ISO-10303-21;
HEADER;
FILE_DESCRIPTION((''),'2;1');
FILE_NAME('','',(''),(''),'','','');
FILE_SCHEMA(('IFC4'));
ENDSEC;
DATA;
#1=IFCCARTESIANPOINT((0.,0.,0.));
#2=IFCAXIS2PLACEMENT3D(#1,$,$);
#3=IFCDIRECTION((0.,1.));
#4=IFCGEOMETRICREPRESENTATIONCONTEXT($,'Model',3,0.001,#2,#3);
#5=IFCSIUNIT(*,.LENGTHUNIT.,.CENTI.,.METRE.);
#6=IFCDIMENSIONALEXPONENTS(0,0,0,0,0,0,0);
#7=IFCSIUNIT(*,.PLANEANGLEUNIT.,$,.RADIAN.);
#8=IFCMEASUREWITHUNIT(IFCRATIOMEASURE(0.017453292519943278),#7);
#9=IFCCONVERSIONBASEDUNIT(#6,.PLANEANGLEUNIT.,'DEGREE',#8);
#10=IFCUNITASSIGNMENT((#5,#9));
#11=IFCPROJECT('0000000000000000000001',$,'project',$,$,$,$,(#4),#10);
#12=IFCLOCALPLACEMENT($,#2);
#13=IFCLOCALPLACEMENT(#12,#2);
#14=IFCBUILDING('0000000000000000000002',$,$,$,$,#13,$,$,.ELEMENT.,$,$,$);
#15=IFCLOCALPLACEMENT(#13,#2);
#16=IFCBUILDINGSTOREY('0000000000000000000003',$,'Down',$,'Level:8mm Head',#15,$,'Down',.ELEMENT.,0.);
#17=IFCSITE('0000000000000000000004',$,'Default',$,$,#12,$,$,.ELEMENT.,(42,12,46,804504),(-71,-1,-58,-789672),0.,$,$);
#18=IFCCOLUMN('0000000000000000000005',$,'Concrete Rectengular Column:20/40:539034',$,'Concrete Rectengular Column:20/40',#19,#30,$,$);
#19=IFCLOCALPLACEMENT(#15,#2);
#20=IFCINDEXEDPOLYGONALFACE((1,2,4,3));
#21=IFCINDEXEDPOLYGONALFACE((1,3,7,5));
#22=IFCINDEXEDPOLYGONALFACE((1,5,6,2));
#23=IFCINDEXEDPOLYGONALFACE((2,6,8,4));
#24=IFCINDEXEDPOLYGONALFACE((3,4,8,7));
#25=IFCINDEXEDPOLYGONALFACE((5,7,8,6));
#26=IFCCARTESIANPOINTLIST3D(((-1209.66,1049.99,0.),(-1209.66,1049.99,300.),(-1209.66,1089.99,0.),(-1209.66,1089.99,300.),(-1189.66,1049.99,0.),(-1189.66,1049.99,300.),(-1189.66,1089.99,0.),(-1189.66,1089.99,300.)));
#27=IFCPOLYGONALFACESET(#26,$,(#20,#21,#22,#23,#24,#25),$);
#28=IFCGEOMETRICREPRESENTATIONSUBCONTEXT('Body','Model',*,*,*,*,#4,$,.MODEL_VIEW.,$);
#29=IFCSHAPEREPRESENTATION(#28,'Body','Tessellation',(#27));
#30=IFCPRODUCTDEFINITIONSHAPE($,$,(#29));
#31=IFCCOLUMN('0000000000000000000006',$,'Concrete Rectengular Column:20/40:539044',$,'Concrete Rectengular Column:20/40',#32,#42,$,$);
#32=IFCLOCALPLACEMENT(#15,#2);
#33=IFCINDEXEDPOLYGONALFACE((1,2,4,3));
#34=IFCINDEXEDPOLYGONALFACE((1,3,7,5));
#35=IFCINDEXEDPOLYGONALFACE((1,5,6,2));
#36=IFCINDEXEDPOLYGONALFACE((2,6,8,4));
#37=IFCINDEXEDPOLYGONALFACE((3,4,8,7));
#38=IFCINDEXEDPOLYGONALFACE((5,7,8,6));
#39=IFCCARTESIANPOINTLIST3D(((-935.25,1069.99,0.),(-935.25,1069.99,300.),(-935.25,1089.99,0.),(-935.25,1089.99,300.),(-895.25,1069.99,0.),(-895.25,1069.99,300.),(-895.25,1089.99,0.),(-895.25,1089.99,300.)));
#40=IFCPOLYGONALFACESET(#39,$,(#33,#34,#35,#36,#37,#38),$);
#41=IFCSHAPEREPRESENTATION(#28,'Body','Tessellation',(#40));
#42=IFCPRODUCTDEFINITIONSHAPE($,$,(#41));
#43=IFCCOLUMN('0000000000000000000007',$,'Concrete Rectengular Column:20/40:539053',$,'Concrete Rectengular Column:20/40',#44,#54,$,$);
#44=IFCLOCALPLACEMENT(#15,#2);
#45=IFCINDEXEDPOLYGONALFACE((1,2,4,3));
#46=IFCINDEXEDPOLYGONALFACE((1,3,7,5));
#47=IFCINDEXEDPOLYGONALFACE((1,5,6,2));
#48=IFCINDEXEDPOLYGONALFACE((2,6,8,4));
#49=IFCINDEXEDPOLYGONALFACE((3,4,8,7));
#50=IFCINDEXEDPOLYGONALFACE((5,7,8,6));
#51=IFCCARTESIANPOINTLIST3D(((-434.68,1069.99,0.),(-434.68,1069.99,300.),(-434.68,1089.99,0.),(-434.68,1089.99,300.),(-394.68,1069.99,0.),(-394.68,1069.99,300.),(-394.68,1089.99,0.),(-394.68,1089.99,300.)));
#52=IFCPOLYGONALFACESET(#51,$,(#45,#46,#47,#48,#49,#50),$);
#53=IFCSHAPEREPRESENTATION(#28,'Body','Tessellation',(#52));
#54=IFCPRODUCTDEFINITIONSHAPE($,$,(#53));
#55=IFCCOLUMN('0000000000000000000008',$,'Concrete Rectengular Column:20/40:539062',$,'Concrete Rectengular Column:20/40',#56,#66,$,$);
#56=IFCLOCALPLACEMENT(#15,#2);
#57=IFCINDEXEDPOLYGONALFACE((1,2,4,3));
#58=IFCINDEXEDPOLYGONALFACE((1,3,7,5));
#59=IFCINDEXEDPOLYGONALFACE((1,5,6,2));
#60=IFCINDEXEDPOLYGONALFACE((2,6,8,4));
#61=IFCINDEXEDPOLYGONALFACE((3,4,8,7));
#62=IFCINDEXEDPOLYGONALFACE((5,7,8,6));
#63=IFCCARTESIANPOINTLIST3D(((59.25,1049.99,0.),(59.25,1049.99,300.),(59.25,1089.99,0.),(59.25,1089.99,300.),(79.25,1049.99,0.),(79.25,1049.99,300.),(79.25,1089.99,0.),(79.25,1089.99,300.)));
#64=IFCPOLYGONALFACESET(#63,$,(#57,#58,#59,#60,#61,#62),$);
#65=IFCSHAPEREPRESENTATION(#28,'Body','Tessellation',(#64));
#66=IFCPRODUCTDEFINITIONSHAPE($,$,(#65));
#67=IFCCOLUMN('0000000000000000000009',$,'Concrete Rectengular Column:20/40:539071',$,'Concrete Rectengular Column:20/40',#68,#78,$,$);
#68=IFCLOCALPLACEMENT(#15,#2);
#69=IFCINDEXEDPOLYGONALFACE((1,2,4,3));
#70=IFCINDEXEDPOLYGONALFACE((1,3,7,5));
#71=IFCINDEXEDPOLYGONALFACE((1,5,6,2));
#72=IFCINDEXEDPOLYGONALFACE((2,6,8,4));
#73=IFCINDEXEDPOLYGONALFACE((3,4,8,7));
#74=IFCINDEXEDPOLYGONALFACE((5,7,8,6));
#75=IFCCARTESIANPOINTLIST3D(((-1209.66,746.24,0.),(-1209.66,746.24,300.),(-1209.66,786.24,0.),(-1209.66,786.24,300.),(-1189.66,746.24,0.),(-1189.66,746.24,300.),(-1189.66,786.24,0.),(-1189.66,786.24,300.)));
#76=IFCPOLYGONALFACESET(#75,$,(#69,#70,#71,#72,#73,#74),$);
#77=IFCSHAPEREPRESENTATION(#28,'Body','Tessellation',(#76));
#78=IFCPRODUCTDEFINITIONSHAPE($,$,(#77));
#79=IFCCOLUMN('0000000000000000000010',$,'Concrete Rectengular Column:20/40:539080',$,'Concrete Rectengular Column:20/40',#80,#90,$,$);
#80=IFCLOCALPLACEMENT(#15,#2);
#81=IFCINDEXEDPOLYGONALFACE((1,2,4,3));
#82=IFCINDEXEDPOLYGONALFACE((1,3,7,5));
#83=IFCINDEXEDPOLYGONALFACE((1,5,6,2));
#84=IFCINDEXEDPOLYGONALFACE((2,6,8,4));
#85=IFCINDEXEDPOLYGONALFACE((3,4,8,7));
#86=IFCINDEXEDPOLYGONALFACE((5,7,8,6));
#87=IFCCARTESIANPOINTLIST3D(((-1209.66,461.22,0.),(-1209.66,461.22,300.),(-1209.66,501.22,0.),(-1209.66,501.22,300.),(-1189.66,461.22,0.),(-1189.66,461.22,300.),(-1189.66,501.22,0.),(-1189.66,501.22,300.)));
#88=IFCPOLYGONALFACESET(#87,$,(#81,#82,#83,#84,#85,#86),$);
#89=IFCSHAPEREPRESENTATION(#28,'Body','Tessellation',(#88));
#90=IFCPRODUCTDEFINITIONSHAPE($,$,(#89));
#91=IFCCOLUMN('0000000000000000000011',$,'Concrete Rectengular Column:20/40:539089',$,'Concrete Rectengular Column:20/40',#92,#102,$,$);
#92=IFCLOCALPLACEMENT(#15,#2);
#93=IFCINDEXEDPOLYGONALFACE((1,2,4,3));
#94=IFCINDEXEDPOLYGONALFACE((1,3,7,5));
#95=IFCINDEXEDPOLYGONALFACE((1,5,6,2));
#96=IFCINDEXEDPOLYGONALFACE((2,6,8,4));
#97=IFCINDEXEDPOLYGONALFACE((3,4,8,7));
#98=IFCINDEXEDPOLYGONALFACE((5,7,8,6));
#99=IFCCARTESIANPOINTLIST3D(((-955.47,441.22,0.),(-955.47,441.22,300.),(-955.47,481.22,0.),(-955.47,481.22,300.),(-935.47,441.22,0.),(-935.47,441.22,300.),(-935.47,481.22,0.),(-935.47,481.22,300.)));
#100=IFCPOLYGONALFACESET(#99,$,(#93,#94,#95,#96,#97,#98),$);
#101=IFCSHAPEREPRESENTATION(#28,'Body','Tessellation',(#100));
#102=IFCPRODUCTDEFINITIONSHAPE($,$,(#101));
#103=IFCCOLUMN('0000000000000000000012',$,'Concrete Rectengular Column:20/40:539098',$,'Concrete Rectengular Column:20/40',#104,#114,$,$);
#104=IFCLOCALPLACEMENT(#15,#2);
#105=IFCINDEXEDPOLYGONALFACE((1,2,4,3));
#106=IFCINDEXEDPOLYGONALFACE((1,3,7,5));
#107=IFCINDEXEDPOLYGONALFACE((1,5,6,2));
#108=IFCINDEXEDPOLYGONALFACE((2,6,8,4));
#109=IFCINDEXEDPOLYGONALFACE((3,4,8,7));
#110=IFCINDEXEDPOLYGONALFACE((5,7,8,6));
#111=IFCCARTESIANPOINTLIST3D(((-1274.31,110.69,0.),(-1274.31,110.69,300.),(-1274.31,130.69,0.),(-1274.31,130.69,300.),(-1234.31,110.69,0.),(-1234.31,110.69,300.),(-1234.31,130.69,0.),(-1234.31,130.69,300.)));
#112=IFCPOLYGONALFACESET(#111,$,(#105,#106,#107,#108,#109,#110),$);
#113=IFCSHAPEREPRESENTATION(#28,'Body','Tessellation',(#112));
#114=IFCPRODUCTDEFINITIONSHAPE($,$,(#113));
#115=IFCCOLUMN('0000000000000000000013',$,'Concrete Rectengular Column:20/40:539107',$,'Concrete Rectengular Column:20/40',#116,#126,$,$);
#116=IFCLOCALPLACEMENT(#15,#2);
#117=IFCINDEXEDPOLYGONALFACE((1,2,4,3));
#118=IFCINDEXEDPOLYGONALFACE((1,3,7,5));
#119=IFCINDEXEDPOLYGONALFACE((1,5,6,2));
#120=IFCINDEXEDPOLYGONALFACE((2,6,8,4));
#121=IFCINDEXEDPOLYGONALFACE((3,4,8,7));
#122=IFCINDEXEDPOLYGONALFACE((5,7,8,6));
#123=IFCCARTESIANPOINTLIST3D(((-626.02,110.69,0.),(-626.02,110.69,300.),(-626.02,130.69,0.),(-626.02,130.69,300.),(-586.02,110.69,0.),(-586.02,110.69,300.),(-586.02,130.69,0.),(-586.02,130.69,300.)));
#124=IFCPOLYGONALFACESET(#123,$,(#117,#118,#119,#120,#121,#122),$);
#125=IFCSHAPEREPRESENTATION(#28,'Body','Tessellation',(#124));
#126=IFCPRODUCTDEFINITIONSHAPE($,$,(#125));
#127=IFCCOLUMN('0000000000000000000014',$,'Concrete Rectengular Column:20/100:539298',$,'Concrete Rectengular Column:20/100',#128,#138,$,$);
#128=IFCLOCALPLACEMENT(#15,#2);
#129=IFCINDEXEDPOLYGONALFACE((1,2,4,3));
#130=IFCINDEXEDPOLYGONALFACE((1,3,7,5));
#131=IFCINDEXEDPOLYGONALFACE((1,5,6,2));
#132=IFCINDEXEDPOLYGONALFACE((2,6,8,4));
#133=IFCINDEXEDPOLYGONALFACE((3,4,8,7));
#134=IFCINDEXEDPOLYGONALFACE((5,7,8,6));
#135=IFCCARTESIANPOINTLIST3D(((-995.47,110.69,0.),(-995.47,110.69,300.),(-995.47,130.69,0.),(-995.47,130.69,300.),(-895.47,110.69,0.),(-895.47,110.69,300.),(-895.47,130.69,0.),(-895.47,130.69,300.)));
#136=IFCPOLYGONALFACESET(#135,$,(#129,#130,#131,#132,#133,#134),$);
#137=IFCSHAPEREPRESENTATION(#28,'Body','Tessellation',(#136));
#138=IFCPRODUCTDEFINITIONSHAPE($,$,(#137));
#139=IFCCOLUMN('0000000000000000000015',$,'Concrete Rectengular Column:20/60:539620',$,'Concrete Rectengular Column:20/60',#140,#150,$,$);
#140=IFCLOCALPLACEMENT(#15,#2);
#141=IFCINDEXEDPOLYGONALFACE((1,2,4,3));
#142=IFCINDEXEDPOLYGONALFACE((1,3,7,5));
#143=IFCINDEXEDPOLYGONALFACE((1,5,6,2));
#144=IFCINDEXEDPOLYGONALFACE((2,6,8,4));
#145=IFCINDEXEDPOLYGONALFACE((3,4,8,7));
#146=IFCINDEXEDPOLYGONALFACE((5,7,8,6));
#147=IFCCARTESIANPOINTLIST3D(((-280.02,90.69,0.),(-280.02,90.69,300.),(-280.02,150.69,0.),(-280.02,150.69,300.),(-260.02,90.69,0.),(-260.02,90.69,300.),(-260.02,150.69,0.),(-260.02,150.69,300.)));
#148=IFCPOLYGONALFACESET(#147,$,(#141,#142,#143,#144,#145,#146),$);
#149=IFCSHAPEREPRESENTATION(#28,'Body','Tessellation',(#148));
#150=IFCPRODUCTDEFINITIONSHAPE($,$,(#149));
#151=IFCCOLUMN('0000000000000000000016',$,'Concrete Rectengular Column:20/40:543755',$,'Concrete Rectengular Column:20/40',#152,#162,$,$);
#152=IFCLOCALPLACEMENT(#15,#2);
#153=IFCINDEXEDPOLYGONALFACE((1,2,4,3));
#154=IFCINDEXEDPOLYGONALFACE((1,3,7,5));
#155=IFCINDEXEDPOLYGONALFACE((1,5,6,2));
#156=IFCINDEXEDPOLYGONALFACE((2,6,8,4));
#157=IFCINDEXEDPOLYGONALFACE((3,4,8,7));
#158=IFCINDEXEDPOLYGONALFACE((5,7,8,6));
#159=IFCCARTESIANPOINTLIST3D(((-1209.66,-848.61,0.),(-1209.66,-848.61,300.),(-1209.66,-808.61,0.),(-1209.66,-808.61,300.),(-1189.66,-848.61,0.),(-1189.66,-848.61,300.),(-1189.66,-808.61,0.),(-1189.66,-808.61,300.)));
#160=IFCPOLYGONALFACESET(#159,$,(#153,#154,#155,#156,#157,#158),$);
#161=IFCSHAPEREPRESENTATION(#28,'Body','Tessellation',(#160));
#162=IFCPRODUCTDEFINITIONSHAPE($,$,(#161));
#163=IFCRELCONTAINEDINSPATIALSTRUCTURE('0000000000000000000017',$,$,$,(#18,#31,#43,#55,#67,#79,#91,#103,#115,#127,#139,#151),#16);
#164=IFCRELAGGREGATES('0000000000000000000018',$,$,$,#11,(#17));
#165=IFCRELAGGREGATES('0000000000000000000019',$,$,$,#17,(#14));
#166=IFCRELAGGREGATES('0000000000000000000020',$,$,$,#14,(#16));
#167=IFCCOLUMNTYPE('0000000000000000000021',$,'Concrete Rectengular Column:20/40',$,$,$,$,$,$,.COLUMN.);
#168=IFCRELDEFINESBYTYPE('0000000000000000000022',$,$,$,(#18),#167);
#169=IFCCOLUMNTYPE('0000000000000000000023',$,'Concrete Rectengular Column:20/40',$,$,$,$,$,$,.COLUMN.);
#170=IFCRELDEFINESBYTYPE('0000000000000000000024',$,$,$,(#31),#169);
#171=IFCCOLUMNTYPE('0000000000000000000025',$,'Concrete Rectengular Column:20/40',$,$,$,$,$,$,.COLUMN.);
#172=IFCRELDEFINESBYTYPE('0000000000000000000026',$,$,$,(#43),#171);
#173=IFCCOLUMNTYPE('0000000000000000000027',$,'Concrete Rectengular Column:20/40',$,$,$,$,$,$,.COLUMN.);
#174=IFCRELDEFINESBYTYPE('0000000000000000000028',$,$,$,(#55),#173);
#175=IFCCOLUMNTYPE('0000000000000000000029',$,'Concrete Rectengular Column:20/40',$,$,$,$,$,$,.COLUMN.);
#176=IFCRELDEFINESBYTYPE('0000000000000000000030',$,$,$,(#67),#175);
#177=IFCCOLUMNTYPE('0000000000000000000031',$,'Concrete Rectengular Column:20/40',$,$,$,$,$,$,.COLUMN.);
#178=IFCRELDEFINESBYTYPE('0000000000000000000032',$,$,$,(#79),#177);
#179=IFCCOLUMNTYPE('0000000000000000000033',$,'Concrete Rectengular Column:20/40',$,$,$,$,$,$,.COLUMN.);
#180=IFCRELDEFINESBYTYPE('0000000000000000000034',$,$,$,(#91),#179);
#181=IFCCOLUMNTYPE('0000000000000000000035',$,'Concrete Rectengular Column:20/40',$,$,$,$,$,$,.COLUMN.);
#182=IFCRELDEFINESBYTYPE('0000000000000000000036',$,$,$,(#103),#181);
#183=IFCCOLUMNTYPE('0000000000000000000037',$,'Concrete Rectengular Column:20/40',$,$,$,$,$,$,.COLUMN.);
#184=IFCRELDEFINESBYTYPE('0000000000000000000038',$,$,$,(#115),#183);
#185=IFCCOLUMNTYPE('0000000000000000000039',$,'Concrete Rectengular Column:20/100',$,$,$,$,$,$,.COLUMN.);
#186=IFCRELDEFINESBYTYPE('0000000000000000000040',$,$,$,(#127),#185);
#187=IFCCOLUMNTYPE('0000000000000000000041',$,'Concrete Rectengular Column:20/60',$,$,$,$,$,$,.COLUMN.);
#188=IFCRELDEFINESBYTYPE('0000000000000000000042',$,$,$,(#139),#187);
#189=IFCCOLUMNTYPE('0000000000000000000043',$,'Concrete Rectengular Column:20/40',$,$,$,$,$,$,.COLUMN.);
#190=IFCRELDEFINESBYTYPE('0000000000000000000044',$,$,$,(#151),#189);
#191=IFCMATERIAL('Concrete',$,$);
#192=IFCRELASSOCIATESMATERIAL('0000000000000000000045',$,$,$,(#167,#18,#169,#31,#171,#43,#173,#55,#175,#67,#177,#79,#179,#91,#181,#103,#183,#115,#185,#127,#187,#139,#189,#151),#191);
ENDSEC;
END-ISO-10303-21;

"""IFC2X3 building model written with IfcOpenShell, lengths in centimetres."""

from ifc_helpers import new_model, entity, si_unit, converted_unit, direction, frame, frame_2d, origin, origin_2d_with_axis, place, context, subcontext, project, spatial, rectangle, extrude, source, transform, mapped, material, type_object, type_shapes, element, save


model = new_model("IFC2X3")

# Units and contexts
model_context = context("Model", 3, precision=0.001, world=origin(), true_north=direction((0.0, 1.0)))
body_context = subcontext(model_context, "Body", "Model", "MODEL_VIEW")
ifc_project = project(units=[si_unit("LENGTHUNIT", "METRE", prefix="CENTI"), converted_unit("PLANEANGLEUNIT", "DEGREE", entity("IfcRatioMeasure", 0.017453292519943278), si_unit("PLANEANGLEUNIT", "RADIAN"), dimensions=[0, 0, 0, 0, 0, 0, 0])], contexts=[model_context])

# Site, building, storey
site_placement = place(None, origin())
site = spatial("IfcSite", under=ifc_project, at=site_placement, Name="Default", CompositionType="ELEMENT", RefLatitude=(42, 12, 46, 804504), RefLongitude=(-71, -1, -58, -789672), RefElevation=0.0)
building_placement = place(site_placement, origin())
building = spatial("IfcBuilding", under=site, at=building_placement, CompositionType="ELEMENT")
storey_placement = place(building_placement, origin())
storey = spatial("IfcBuildingStorey", under=building, at=storey_placement, Name="Down", ObjectType="Level:8mm Head", LongName="Down", CompositionType="ELEMENT", Elevation=0.0)

# Columns
ifc_material = material(Name="Concrete")
column_type_1 = type_object("IfcColumnType", Name="Concrete Rectengular Column:20/40", PredefinedType="COLUMN", material=ifc_material)
shared_shape_1 = source(origin(), body_context, "Body", "SweptSolid", [
    extrude(rectangle(XDim=40.0, YDim=20.0, at=frame_2d((0.0, 0.0), x_axis=(1.0, 0.0))), frame((-1199.66, 1069.99, 0.0), z_axis=(0.0, 0.0, 1.0), x_axis=(0.0, -1.0, 0.0)), (0.0, 0.0, 1.0), 300.0),
])
type_shapes(column_type_1, [shared_shape_1])
column_1_placement = place(storey_placement, origin())
element("IfcColumn", 1, at=column_1_placement, inside=storey, type_object=column_type_1, material=ifc_material, Name="Concrete Rectengular Column:20/40:539034", ObjectType="Concrete Rectengular Column:20/40", context=body_context, shape_type="MappedRepresentation", body=[
    mapped(shared_shape_1, transform((0.0, 0.0, 0.0), scale=1.0)),
])
column_type_2 = type_object("IfcColumnType", Name="Concrete Rectengular Column:20/40", PredefinedType="COLUMN", material=ifc_material)
shared_shape_2 = source(origin(), body_context, "Body", "SweptSolid", [
    extrude(rectangle(XDim=20.0, YDim=40.0, at=frame_2d((0.0, 0.0), x_axis=(1.0, 0.0))), frame((-915.25, 1079.99, 0.0), z_axis=(0.0, 0.0, 1.0), x_axis=(0.0, -1.0, 0.0)), (0.0, 0.0, 1.0), 300.0),
])
type_shapes(column_type_2, [shared_shape_2])
column_2_placement = place(storey_placement, origin())
element("IfcColumn", 2, at=column_2_placement, inside=storey, type_object=column_type_2, material=ifc_material, Name="Concrete Rectengular Column:20/40:539044", ObjectType="Concrete Rectengular Column:20/40", context=body_context, shape_type="MappedRepresentation", body=[
    mapped(shared_shape_2, transform((0.0, 0.0, 0.0), scale=1.0)),
])
column_type_3 = type_object("IfcColumnType", Name="Concrete Rectengular Column:20/40", PredefinedType="COLUMN", material=ifc_material)
shared_shape_3 = source(origin(), body_context, "Body", "SweptSolid", [
    extrude(rectangle(XDim=20.0, YDim=40.0, at=frame_2d((0.0, 0.0), x_axis=(1.0, 0.0))), frame((-414.68, 1079.99, 0.0), z_axis=(0.0, 0.0, 1.0), x_axis=(0.0, -1.0, 0.0)), (0.0, 0.0, 1.0), 300.0),
])
type_shapes(column_type_3, [shared_shape_3])
column_3_placement = place(storey_placement, origin())
element("IfcColumn", 3, at=column_3_placement, inside=storey, type_object=column_type_3, material=ifc_material, Name="Concrete Rectengular Column:20/40:539053", ObjectType="Concrete Rectengular Column:20/40", context=body_context, shape_type="MappedRepresentation", body=[
    mapped(shared_shape_3, transform((0.0, 0.0, 0.0), scale=1.0)),
])
column_type_4 = type_object("IfcColumnType", Name="Concrete Rectengular Column:20/40", PredefinedType="COLUMN", material=ifc_material)
shared_shape_4 = source(origin(), body_context, "Body", "SweptSolid", [
    extrude(rectangle(XDim=40.0, YDim=20.0, at=origin_2d_with_axis()), frame((69.25, 1069.99, 0.0), z_axis=(0.0, 0.0, 1.0), x_axis=(0.0, -1.0, 0.0)), (0.0, 0.0, 1.0), 300.0),
])
type_shapes(column_type_4, [shared_shape_4])
column_4_placement = place(storey_placement, origin())
element("IfcColumn", 4, at=column_4_placement, inside=storey, type_object=column_type_4, material=ifc_material, Name="Concrete Rectengular Column:20/40:539062", ObjectType="Concrete Rectengular Column:20/40", context=body_context, shape_type="MappedRepresentation", body=[
    mapped(shared_shape_4, transform((0.0, 0.0, 0.0), scale=1.0)),
])
column_type_5 = type_object("IfcColumnType", Name="Concrete Rectengular Column:20/40", PredefinedType="COLUMN", material=ifc_material)
shared_shape_5 = source(origin(), body_context, "Body", "SweptSolid", [
    extrude(rectangle(XDim=40.0, YDim=20.0, at=frame_2d((0.0, 0.0), x_axis=(1.0, 0.0))), frame((-1199.66, 766.24, 0.0), z_axis=(0.0, 0.0, 1.0), x_axis=(0.0, -1.0, 0.0)), (0.0, 0.0, 1.0), 300.0),
])
type_shapes(column_type_5, [shared_shape_5])
column_5_placement = place(storey_placement, origin())
element("IfcColumn", 5, at=column_5_placement, inside=storey, type_object=column_type_5, material=ifc_material, Name="Concrete Rectengular Column:20/40:539071", ObjectType="Concrete Rectengular Column:20/40", context=body_context, shape_type="MappedRepresentation", body=[
    mapped(shared_shape_5, transform((0.0, 0.0, 0.0), scale=1.0)),
])
column_type_6 = type_object("IfcColumnType", Name="Concrete Rectengular Column:20/40", PredefinedType="COLUMN", material=ifc_material)
shared_shape_6 = source(origin(), body_context, "Body", "SweptSolid", [
    extrude(rectangle(XDim=40.0, YDim=20.0, at=frame_2d((0.0, 0.0), x_axis=(1.0, 0.0))), frame((-1199.66, 481.22, 0.0), z_axis=(0.0, 0.0, 1.0), x_axis=(0.0, -1.0, 0.0)), (0.0, 0.0, 1.0), 300.0),
])
type_shapes(column_type_6, [shared_shape_6])
column_6_placement = place(storey_placement, origin())
element("IfcColumn", 6, at=column_6_placement, inside=storey, type_object=column_type_6, material=ifc_material, Name="Concrete Rectengular Column:20/40:539080", ObjectType="Concrete Rectengular Column:20/40", context=body_context, shape_type="MappedRepresentation", body=[
    mapped(shared_shape_6, transform((0.0, 0.0, 0.0), scale=1.0)),
])
column_type_7 = type_object("IfcColumnType", Name="Concrete Rectengular Column:20/40", PredefinedType="COLUMN", material=ifc_material)
shared_shape_7 = source(origin(), body_context, "Body", "SweptSolid", [
    extrude(rectangle(XDim=40.0, YDim=20.0, at=frame_2d((0.0, 0.0), x_axis=(1.0, 0.0))), frame((-945.47, 461.22, 0.0), z_axis=(0.0, 0.0, 1.0), x_axis=(0.0, -1.0, 0.0)), (0.0, 0.0, 1.0), 300.0),
])
type_shapes(column_type_7, [shared_shape_7])
column_7_placement = place(storey_placement, origin())
element("IfcColumn", 7, at=column_7_placement, inside=storey, type_object=column_type_7, material=ifc_material, Name="Concrete Rectengular Column:20/40:539089", ObjectType="Concrete Rectengular Column:20/40", context=body_context, shape_type="MappedRepresentation", body=[
    mapped(shared_shape_7, transform((0.0, 0.0, 0.0), scale=1.0)),
])
column_type_8 = type_object("IfcColumnType", Name="Concrete Rectengular Column:20/40", PredefinedType="COLUMN", material=ifc_material)
shared_shape_8 = source(origin(), body_context, "Body", "SweptSolid", [
    extrude(rectangle(XDim=20.0, YDim=40.0, at=frame_2d((0.0, 0.0), x_axis=(1.0, 0.0))), frame((-1254.31, 120.69, 0.0), z_axis=(0.0, 0.0, 1.0), x_axis=(0.0, -1.0, 0.0)), (0.0, 0.0, 1.0), 300.0),
])
type_shapes(column_type_8, [shared_shape_8])
column_8_placement = place(storey_placement, origin())
element("IfcColumn", 8, at=column_8_placement, inside=storey, type_object=column_type_8, material=ifc_material, Name="Concrete Rectengular Column:20/40:539098", ObjectType="Concrete Rectengular Column:20/40", context=body_context, shape_type="MappedRepresentation", body=[
    mapped(shared_shape_8, transform((0.0, 0.0, 0.0), scale=1.0)),
])
column_type_9 = type_object("IfcColumnType", Name="Concrete Rectengular Column:20/40", PredefinedType="COLUMN", material=ifc_material)
shared_shape_9 = source(origin(), body_context, "Body", "SweptSolid", [
    extrude(rectangle(XDim=20.0, YDim=40.0, at=frame_2d((0.0, 0.0), x_axis=(1.0, 0.0))), frame((-606.02, 120.69, 0.0), z_axis=(0.0, 0.0, 1.0), x_axis=(0.0, -1.0, 0.0)), (0.0, 0.0, 1.0), 300.0),
])
type_shapes(column_type_9, [shared_shape_9])
column_9_placement = place(storey_placement, origin())
element("IfcColumn", 9, at=column_9_placement, inside=storey, type_object=column_type_9, material=ifc_material, Name="Concrete Rectengular Column:20/40:539107", ObjectType="Concrete Rectengular Column:20/40", context=body_context, shape_type="MappedRepresentation", body=[
    mapped(shared_shape_9, transform((0.0, 0.0, 0.0), scale=1.0)),
])
column_type_10 = type_object("IfcColumnType", Name="Concrete Rectengular Column:20/100", PredefinedType="COLUMN", material=ifc_material)
shared_shape_10 = source(origin(), body_context, "Body", "SweptSolid", [
    extrude(rectangle(XDim=20.0, YDim=100.0, at=frame_2d((0.0, 0.0), x_axis=(1.0, 0.0))), frame((-945.47, 120.69, 0.0), z_axis=(0.0, 0.0, 1.0), x_axis=(0.0, -1.0, 0.0)), (0.0, 0.0, 1.0), 300.0),
])
type_shapes(column_type_10, [shared_shape_10])
column_10_placement = place(storey_placement, origin())
element("IfcColumn", 10, at=column_10_placement, inside=storey, type_object=column_type_10, material=ifc_material, Name="Concrete Rectengular Column:20/100:539298", ObjectType="Concrete Rectengular Column:20/100", context=body_context, shape_type="MappedRepresentation", body=[
    mapped(shared_shape_10, transform((0.0, 0.0, 0.0), scale=1.0)),
])
column_type_11 = type_object("IfcColumnType", Name="Concrete Rectengular Column:20/60", PredefinedType="COLUMN", material=ifc_material)
shared_shape_11 = source(origin(), body_context, "Body", "SweptSolid", [
    extrude(rectangle(XDim=60.0, YDim=20.0, at=origin_2d_with_axis()), frame((-270.02, 120.69, 0.0), z_axis=(0.0, 0.0, 1.0), x_axis=(0.0, -1.0, 0.0)), (0.0, 0.0, 1.0), 300.0),
])
type_shapes(column_type_11, [shared_shape_11])
column_11_placement = place(storey_placement, origin())
element("IfcColumn", 11, at=column_11_placement, inside=storey, type_object=column_type_11, material=ifc_material, Name="Concrete Rectengular Column:20/60:539620", ObjectType="Concrete Rectengular Column:20/60", context=body_context, shape_type="MappedRepresentation", body=[
    mapped(shared_shape_11, transform((0.0, 0.0, 0.0), scale=1.0)),
])
column_type_12 = type_object("IfcColumnType", Name="Concrete Rectengular Column:20/40", PredefinedType="COLUMN", material=ifc_material)
shared_shape_12 = source(origin(), body_context, "Body", "SweptSolid", [
    extrude(rectangle(XDim=40.0, YDim=20.0, at=frame_2d((0.0, 0.0), x_axis=(1.0, 0.0))), frame((-1199.66, -828.61, 0.0), z_axis=(0.0, 0.0, 1.0), x_axis=(0.0, -1.0, 0.0)), (0.0, 0.0, 1.0), 300.0),
])
type_shapes(column_type_12, [shared_shape_12])
column_12_placement = place(storey_placement, origin())
element("IfcColumn", 12, at=column_12_placement, inside=storey, type_object=column_type_12, material=ifc_material, Name="Concrete Rectengular Column:20/40:543755", ObjectType="Concrete Rectengular Column:20/40", context=body_context, shape_type="MappedRepresentation", body=[
    mapped(shared_shape_12, transform((0.0, 0.0, 0.0), scale=1.0)),
])

save(model, "model.ifc")
